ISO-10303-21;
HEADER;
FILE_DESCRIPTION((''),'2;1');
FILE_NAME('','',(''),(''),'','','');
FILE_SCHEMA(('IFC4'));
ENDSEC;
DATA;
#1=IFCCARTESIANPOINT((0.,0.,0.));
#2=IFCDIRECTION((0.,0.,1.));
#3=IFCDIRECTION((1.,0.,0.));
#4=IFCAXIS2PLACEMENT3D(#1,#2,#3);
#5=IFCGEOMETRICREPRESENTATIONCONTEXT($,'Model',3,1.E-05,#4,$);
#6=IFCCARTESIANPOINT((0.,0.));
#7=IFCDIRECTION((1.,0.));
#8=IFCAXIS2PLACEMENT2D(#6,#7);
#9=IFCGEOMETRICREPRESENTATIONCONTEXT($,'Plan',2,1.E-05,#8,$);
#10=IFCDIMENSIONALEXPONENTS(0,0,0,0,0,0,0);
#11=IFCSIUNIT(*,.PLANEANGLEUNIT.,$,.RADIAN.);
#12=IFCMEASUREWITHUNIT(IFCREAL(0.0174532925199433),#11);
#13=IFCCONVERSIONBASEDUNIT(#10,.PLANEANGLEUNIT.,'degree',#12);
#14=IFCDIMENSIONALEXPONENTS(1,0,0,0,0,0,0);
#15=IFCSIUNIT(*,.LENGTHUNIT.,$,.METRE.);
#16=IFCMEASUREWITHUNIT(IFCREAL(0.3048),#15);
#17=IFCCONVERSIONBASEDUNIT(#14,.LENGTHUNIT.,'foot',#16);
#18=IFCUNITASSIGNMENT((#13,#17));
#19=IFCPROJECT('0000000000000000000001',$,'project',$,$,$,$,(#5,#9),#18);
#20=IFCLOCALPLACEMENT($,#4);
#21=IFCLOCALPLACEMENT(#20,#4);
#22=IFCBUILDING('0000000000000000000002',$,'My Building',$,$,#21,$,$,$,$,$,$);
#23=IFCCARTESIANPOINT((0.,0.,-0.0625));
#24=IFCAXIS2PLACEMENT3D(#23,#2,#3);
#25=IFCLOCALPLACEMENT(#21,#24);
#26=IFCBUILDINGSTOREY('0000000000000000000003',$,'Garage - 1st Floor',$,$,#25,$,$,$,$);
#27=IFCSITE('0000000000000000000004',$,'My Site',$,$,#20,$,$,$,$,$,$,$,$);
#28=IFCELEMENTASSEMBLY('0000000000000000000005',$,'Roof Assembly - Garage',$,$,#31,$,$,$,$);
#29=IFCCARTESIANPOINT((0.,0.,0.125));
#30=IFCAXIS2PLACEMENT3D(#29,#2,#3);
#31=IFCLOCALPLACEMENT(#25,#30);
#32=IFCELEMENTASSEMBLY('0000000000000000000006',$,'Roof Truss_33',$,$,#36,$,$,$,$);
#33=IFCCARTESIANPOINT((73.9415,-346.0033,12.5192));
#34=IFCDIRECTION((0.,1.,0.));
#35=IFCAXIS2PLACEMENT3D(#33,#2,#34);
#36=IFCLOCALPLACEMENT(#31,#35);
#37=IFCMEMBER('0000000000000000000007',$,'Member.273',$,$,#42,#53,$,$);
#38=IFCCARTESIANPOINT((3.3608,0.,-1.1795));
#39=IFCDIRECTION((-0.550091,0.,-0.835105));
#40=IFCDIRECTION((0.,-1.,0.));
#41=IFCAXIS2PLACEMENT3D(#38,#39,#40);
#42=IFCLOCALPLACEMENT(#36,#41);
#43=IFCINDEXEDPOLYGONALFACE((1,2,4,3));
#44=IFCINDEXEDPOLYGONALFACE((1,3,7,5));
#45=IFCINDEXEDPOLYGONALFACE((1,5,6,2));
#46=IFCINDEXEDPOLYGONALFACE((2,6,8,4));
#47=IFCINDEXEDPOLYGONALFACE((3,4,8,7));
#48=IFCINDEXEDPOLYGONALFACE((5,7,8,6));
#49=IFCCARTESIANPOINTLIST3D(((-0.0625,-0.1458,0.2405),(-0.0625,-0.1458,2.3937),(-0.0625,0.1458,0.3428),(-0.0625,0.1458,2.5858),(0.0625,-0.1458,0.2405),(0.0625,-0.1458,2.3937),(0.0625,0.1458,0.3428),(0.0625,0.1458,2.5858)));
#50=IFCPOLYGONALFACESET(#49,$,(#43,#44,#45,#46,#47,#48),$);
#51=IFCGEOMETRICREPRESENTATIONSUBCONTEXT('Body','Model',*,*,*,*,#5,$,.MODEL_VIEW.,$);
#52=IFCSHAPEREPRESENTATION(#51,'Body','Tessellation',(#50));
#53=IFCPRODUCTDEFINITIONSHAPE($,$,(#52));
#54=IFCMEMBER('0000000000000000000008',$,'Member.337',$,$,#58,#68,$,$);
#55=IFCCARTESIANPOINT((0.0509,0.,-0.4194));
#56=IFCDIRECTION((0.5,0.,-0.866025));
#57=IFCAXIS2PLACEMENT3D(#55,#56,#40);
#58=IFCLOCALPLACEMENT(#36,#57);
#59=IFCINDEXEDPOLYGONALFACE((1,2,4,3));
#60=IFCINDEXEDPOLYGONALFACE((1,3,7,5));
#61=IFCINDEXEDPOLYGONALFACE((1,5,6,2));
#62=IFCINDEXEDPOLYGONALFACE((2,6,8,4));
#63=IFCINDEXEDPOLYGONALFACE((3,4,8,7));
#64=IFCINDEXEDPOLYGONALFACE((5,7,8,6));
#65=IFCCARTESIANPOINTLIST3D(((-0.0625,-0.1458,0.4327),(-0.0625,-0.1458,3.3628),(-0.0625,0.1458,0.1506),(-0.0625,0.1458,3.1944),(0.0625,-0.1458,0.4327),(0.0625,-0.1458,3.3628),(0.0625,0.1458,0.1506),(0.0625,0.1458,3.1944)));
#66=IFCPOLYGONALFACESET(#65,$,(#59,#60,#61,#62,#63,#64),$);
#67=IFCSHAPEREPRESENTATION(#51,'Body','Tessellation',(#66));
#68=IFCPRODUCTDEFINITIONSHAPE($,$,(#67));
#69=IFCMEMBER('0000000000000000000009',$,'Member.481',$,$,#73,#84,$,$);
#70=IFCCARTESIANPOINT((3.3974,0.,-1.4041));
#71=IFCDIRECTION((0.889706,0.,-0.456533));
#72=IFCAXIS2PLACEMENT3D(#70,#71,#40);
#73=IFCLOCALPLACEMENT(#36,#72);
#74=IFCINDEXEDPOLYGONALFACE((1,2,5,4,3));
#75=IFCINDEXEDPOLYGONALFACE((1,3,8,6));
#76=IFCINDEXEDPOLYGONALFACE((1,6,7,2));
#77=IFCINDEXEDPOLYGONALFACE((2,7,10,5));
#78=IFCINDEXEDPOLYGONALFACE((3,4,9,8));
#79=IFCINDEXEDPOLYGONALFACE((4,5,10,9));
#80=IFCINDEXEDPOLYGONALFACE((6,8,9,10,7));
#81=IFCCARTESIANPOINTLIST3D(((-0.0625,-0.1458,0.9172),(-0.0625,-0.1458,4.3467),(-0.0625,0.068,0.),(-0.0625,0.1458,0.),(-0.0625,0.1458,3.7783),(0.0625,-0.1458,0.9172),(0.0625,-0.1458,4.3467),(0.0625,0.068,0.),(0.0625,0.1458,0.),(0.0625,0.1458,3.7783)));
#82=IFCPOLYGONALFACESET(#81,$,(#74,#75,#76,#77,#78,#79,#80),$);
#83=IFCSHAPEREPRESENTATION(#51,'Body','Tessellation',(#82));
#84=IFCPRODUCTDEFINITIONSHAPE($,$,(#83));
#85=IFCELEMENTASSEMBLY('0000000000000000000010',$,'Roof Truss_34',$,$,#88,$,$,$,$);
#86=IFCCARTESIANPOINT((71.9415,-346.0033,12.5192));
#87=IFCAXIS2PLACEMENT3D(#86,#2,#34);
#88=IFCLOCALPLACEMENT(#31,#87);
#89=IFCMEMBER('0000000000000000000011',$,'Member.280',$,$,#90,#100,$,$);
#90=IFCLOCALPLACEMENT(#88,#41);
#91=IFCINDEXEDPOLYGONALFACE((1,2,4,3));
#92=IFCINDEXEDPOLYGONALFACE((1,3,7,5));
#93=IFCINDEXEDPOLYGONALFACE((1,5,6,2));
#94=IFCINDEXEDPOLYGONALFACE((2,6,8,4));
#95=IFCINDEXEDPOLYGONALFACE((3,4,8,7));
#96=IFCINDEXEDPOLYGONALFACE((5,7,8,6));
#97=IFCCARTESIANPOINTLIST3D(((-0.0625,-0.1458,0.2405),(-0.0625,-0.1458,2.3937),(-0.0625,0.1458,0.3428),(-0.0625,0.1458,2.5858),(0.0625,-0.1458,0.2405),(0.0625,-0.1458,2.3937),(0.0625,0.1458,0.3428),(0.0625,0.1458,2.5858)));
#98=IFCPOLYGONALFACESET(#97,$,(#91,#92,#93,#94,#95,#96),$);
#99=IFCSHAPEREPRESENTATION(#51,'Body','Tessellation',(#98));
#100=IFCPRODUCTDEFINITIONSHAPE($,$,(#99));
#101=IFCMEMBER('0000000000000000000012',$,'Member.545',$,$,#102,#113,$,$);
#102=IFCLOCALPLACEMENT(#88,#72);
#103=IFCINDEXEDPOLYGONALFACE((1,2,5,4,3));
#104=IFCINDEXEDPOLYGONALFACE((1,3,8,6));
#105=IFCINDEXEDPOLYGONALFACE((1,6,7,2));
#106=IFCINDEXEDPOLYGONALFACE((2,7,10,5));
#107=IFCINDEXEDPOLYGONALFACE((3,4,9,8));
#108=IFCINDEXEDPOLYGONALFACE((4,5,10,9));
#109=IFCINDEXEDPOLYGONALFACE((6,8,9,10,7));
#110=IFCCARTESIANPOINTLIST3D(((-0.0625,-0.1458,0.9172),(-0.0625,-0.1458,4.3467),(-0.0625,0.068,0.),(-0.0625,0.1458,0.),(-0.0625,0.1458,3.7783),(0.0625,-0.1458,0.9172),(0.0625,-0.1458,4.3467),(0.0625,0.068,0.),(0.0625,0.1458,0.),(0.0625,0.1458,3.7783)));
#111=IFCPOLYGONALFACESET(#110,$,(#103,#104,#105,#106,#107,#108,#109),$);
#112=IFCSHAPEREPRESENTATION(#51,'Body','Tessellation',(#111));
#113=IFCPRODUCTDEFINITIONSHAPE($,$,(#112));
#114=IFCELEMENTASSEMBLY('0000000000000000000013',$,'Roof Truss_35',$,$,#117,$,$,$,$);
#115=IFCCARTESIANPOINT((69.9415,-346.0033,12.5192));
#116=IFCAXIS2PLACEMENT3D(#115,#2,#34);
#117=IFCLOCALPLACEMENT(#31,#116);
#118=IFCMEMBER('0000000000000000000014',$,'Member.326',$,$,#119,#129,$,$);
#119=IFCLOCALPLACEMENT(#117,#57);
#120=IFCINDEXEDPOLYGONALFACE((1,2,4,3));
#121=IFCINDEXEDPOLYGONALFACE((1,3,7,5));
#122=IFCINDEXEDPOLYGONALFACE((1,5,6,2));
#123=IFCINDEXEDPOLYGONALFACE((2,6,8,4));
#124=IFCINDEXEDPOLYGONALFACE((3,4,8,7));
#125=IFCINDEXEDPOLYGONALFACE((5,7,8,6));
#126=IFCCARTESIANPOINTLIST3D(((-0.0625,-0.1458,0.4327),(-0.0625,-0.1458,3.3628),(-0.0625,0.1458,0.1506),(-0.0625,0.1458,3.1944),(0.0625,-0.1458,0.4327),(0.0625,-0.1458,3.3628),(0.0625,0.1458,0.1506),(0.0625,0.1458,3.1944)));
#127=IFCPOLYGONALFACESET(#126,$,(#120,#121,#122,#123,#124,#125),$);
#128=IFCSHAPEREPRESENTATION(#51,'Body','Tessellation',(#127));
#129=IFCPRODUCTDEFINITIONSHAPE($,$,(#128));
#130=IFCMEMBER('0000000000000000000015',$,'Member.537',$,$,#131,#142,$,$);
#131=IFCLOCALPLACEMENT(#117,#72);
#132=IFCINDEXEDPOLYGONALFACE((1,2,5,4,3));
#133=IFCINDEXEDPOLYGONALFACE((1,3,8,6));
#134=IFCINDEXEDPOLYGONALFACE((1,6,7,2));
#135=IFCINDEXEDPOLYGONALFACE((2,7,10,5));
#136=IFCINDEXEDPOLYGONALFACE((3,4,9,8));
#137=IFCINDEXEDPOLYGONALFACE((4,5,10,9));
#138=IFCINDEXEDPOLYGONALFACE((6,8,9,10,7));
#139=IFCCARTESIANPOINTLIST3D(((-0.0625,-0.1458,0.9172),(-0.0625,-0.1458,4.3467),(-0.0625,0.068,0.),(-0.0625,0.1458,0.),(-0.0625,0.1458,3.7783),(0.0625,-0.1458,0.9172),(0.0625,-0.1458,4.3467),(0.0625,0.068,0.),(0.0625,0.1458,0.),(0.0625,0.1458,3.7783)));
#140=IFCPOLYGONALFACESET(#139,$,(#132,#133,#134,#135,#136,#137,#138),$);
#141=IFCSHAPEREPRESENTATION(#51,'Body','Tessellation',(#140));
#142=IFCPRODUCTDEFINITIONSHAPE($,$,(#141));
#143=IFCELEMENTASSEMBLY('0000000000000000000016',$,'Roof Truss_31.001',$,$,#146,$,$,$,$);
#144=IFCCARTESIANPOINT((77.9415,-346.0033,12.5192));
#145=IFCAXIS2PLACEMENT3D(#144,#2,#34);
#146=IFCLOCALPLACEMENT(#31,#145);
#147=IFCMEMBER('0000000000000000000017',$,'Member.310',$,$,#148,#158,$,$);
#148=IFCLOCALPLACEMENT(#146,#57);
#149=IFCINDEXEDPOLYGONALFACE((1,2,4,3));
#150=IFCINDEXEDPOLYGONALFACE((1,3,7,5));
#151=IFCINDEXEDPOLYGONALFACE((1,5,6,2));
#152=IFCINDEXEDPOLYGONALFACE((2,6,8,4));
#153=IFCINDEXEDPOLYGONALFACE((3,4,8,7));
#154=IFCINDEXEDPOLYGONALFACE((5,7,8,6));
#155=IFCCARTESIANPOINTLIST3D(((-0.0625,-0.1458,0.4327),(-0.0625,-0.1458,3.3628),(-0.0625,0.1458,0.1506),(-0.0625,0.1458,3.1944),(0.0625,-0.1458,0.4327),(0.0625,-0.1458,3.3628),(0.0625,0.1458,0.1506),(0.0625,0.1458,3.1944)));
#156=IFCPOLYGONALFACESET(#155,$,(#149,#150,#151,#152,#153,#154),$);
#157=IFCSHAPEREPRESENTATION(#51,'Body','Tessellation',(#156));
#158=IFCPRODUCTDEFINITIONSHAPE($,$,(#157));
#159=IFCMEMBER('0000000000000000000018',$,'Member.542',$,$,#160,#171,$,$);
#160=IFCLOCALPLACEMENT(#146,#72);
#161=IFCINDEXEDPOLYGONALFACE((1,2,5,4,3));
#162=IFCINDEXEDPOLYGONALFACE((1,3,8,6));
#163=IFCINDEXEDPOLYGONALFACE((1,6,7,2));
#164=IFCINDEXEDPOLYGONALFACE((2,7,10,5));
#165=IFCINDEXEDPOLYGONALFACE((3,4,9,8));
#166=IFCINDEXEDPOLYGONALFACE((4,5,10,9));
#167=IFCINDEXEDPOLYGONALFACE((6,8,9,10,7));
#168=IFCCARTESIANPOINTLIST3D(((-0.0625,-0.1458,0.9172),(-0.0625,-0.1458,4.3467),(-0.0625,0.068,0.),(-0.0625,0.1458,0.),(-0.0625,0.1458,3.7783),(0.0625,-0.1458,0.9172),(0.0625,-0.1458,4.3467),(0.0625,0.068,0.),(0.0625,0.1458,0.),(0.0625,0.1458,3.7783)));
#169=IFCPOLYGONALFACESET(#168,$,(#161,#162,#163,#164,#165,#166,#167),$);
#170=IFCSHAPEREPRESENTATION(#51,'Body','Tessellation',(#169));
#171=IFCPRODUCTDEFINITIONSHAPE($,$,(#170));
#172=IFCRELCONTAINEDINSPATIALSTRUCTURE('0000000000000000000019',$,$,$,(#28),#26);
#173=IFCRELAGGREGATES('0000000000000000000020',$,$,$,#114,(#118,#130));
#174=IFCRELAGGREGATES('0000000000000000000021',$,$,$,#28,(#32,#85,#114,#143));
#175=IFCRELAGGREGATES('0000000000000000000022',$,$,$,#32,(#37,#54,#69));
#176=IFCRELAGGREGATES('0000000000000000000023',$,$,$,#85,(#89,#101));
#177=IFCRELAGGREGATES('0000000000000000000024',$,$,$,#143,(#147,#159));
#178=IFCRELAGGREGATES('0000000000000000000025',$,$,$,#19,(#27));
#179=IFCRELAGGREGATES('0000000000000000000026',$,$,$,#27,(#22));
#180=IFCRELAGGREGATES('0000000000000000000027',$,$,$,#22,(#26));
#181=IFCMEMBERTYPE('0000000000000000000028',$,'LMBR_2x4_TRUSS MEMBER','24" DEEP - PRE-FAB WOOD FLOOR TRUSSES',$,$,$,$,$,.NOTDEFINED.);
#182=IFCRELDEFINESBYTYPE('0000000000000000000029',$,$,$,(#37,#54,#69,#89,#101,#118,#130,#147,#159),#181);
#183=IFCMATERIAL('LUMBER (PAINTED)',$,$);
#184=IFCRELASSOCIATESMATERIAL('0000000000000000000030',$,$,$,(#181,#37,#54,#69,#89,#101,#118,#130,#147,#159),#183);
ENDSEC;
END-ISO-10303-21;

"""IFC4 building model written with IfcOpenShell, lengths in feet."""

from ifc_helpers import new_model, entity, si_unit, converted_unit, frame, origin_with_axes, origin_2d_with_axis, place, context, subcontext, project, spatial, indexed_curve, outline, extrude, clip, halfspace, material, material_profile, profile_set, profile_usage, type_object, element, aggregate, save


model = new_model("IFC4")

# Units and contexts
model_context = context("Model", 3, precision=1e-05, world=origin_with_axes())
plan_context = context("Plan", 2, precision=1e-05, world=origin_2d_with_axis())
body_context = subcontext(model_context, "Body", "Model", "MODEL_VIEW")
ifc_project = project(units=[converted_unit("PLANEANGLEUNIT", "degree", entity("IfcReal", 0.0174532925199433), si_unit("PLANEANGLEUNIT", "RADIAN"), dimensions=[0, 0, 0, 0, 0, 0, 0]), converted_unit("LENGTHUNIT", "foot", entity("IfcReal", 0.3048), si_unit("LENGTHUNIT", "METRE"), dimensions=[1, 0, 0, 0, 0, 0, 0])], contexts=[model_context, plan_context])

# Site, building, storey
site_placement = place(None, origin_with_axes())
site = spatial("IfcSite", under=ifc_project, at=site_placement, Name="My Site")
building_placement = place(site_placement, origin_with_axes())
building = spatial("IfcBuilding", under=site, at=building_placement, Name="My Building")
storey_placement = place(building_placement, frame((0.0, 0.0, -0.0625), z_axis=(0.0, 0.0, 1.0), x_axis=(1.0, 0.0, 0.0)))
storey = spatial("IfcBuildingStorey", under=building, at=storey_placement, Name="Garage - 1st Floor")

# Element assemblies, members
assembly_1_placement = place(storey_placement, frame((0.0, 0.0, 0.125), z_axis=(0.0, 0.0, 1.0), x_axis=(1.0, 0.0, 0.0)))
assembly_1 = element("IfcElementAssembly", 1, at=assembly_1_placement, inside=storey, Name="Roof Assembly - Garage")
assembly_2_placement = place(assembly_1_placement, frame((73.9415, -346.0033, 12.5192), z_axis=(0.0, 0.0, 1.0), x_axis=(0.0, 1.0, 0.0)))
assembly_2 = element("IfcElementAssembly", 2, at=assembly_2_placement, Name="Roof Truss_33")
ifc_material = material(Name="LUMBER (PAINTED)")
ifc_material_profile_1 = material_profile(ifc_material, outline(indexed_curve([(-0.0625, -0.1458), (0.0625, -0.1458), (0.0625, 0.1458), (-0.0625, 0.1458), (-0.0625, -0.1458)])))
ifc_profile_set_1 = profile_set([ifc_material_profile_1])
ifc_profile_usage_1 = profile_usage(ifc_profile_set_1)
member_type_1 = type_object("IfcMemberType", Name="LMBR_2x4_TRUSS MEMBER", Description="24\" DEEP - PRE-FAB WOOD FLOOR TRUSSES", PredefinedType="NOTDEFINED", material=ifc_profile_set_1)
member_1_placement = place(assembly_2_placement, frame((3.3608, 0.0, -1.1795), z_axis=(-0.550091, 0.0, -0.835105), x_axis=(0.0, -1.0, 0.0)))
member_1 = element("IfcMember", 3, at=member_1_placement, type_object=member_type_1, material=ifc_profile_usage_1, Name="Member.273", context=body_context, shape_type="Clipping", body=[
    clip(clip(extrude(outline(indexed_curve([(-0.0625, -0.1458), (0.0625, -0.1458), (0.0625, 0.1458), (-0.0625, 0.1458), (-0.0625, -0.1458)])), origin_with_axes(), (0.0, 0.0, 1.0), 2.7814), halfspace(frame((0.0, 3.2555, 1.4338), z_axis=(0.0, 0.331062, -0.943609), x_axis=(1.0, 0.0, 0.0)), False)), halfspace(frame((0.0, -4.6352, -0.5634), z_axis=(0.0, -0.550091, 0.835105), x_axis=(-1.0, 0.0, 0.0)), False)),
])
ifc_profile_usage_2 = profile_usage(ifc_profile_set_1)
member_2_placement = place(assembly_2_placement, frame((0.0509, 0.0, -0.4194), z_axis=(0.5, 0.0, -0.866025), x_axis=(0.0, -1.0, 0.0)))
member_2 = element("IfcMember", 4, at=member_2_placement, type_object=member_type_1, material=ifc_profile_usage_2, Name="Member.337", context=body_context, shape_type="Clipping", body=[
    clip(clip(extrude(outline(indexed_curve([(-0.0625, -0.1458), (0.0625, -0.1458), (0.0625, 0.1458), (-0.0625, 0.1458), (-0.0625, -0.1458)])), origin_with_axes(), (0.0, 0.0, 1.0), 3.5703), halfspace(frame((0.0, -5.0674, 6.2043), z_axis=(0.0, 0.5, 0.866025), x_axis=(1.0, 0.0, 0.0)), False)), halfspace(frame((0.0, 0.2544, 0.0456), z_axis=(0.0, -0.695161, -0.718855), x_axis=(-1.0, 0.0, 0.0)), False)),
])
ifc_profile_usage_3 = profile_usage(ifc_profile_set_1)
member_3_placement = place(assembly_2_placement, frame((3.3974, 0.0, -1.4041), z_axis=(0.889706, 0.0, -0.456533), x_axis=(0.0, -1.0, 0.0)))
member_3 = element("IfcMember", 5, at=member_3_placement, type_object=member_type_1, material=ifc_profile_usage_3, Name="Member.481", context=body_context, shape_type="Clipping", body=[
    clip(clip(extrude(outline(indexed_curve([(-0.0625, -0.1458), (0.0625, -0.1458), (0.0625, 0.1458), (-0.0625, 0.1458), (-0.0625, -0.1458)])), origin_with_axes(), (0.0, 0.0, 1.0), 4.3542), halfspace(frame((0.0, -0.2419, 4.5339), z_axis=(0.0, 0.889707, 0.456533), x_axis=(1.0, 0.0, 0.0)), False)), halfspace(frame((0.0, 0.8902, -3.5265), z_axis=(0.0, -0.973882, -0.227053), x_axis=(-1.0, 0.0, 0.0)), False)),
])
assembly_3_placement = place(assembly_1_placement, frame((71.9415, -346.0033, 12.5192), z_axis=(0.0, 0.0, 1.0), x_axis=(0.0, 1.0, 0.0)))
assembly_3 = element("IfcElementAssembly", 6, at=assembly_3_placement, Name="Roof Truss_34")
ifc_profile_usage_4 = profile_usage(ifc_profile_set_1)
member_4_placement = place(assembly_3_placement, frame((3.3608, 0.0, -1.1795), z_axis=(-0.550091, 0.0, -0.835105), x_axis=(0.0, -1.0, 0.0)))
member_4 = element("IfcMember", 7, at=member_4_placement, type_object=member_type_1, material=ifc_profile_usage_4, Name="Member.280", context=body_context, shape_type="Clipping", body=[
    clip(clip(extrude(outline(indexed_curve([(-0.0625, -0.1458), (0.0625, -0.1458), (0.0625, 0.1458), (-0.0625, 0.1458), (-0.0625, -0.1458)])), origin_with_axes(), (0.0, 0.0, 1.0), 2.7814), halfspace(frame((0.0, 3.2555, 1.4338), z_axis=(0.0, 0.331062, -0.943609), x_axis=(1.0, 0.0, 0.0)), False)), halfspace(frame((0.0, -4.6352, -0.5634), z_axis=(0.0, -0.550091, 0.835105), x_axis=(-1.0, 0.0, 0.0)), False)),
])
ifc_profile_usage_5 = profile_usage(ifc_profile_set_1)
member_5_placement = place(assembly_3_placement, frame((3.3974, 0.0, -1.4041), z_axis=(0.889706, 0.0, -0.456533), x_axis=(0.0, -1.0, 0.0)))
member_5 = element("IfcMember", 8, at=member_5_placement, type_object=member_type_1, material=ifc_profile_usage_5, Name="Member.545", context=body_context, shape_type="Clipping", body=[
    clip(clip(extrude(outline(indexed_curve([(-0.0625, -0.1458), (0.0625, -0.1458), (0.0625, 0.1458), (-0.0625, 0.1458), (-0.0625, -0.1458)])), origin_with_axes(), (0.0, 0.0, 1.0), 4.3542), halfspace(frame((0.0, -0.2419, 4.5339), z_axis=(0.0, 0.889707, 0.456533), x_axis=(1.0, 0.0, 0.0)), False)), halfspace(frame((0.0, 0.8902, -3.5265), z_axis=(0.0, -0.973882, -0.227053), x_axis=(-1.0, 0.0, 0.0)), False)),
])
assembly_4_placement = place(assembly_1_placement, frame((69.9415, -346.0033, 12.5192), z_axis=(0.0, 0.0, 1.0), x_axis=(0.0, 1.0, 0.0)))
assembly_4 = element("IfcElementAssembly", 9, at=assembly_4_placement, Name="Roof Truss_35")
ifc_profile_usage_6 = profile_usage(ifc_profile_set_1)
member_6_placement = place(assembly_4_placement, frame((0.0509, 0.0, -0.4194), z_axis=(0.5, 0.0, -0.866025), x_axis=(0.0, -1.0, 0.0)))
member_6 = element("IfcMember", 10, at=member_6_placement, type_object=member_type_1, material=ifc_profile_usage_6, Name="Member.326", context=body_context, shape_type="Clipping", body=[
    clip(clip(extrude(outline(indexed_curve([(-0.0625, -0.1458), (0.0625, -0.1458), (0.0625, 0.1458), (-0.0625, 0.1458), (-0.0625, -0.1458)])), origin_with_axes(), (0.0, 0.0, 1.0), 3.5703), halfspace(frame((0.0, -5.0674, 6.2043), z_axis=(0.0, 0.5, 0.866025), x_axis=(1.0, 0.0, 0.0)), False)), halfspace(frame((0.0, 0.2544, 0.0456), z_axis=(0.0, -0.695161, -0.718855), x_axis=(-1.0, 0.0, 0.0)), False)),
])
ifc_profile_usage_7 = profile_usage(ifc_profile_set_1)
member_7_placement = place(assembly_4_placement, frame((3.3974, 0.0, -1.4041), z_axis=(0.889706, 0.0, -0.456533), x_axis=(0.0, -1.0, 0.0)))
member_7 = element("IfcMember", 11, at=member_7_placement, type_object=member_type_1, material=ifc_profile_usage_7, Name="Member.537", context=body_context, shape_type="Clipping", body=[
    clip(clip(extrude(outline(indexed_curve([(-0.0625, -0.1458), (0.0625, -0.1458), (0.0625, 0.1458), (-0.0625, 0.1458), (-0.0625, -0.1458)])), origin_with_axes(), (0.0, 0.0, 1.0), 4.3542), halfspace(frame((0.0, -0.2419, 4.5339), z_axis=(0.0, 0.889707, 0.456533), x_axis=(1.0, 0.0, 0.0)), False)), halfspace(frame((0.0, 0.8902, -3.5265), z_axis=(0.0, -0.973882, -0.227053), x_axis=(-1.0, 0.0, 0.0)), False)),
])
aggregate(assembly_4, [member_6, member_7])
assembly_5_placement = place(assembly_1_placement, frame((77.9415, -346.0033, 12.5192), z_axis=(0.0, 0.0, 1.0), x_axis=(0.0, 1.0, 0.0)))
assembly_5 = element("IfcElementAssembly", 12, at=assembly_5_placement, Name="Roof Truss_31.001")
ifc_profile_usage_8 = profile_usage(ifc_profile_set_1)
member_8_placement = place(assembly_5_placement, frame((0.0509, 0.0, -0.4194), z_axis=(0.5, 0.0, -0.866025), x_axis=(0.0, -1.0, 0.0)))
member_8 = element("IfcMember", 13, at=member_8_placement, type_object=member_type_1, material=ifc_profile_usage_8, Name="Member.310", context=body_context, shape_type="Clipping", body=[
    clip(clip(extrude(outline(indexed_curve([(-0.0625, -0.1458), (0.0625, -0.1458), (0.0625, 0.1458), (-0.0625, 0.1458), (-0.0625, -0.1458)])), origin_with_axes(), (0.0, 0.0, 1.0), 3.5703), halfspace(frame((0.0, -5.0674, 6.2043), z_axis=(0.0, 0.5, 0.866025), x_axis=(1.0, 0.0, 0.0)), False)), halfspace(frame((0.0, 0.2544, 0.0456), z_axis=(0.0, -0.695161, -0.718855), x_axis=(-1.0, 0.0, 0.0)), False)),
])
ifc_profile_usage_9 = profile_usage(ifc_profile_set_1)
member_9_placement = place(assembly_5_placement, frame((3.3974, 0.0, -1.4041), z_axis=(0.889706, 0.0, -0.456533), x_axis=(0.0, -1.0, 0.0)))
member_9 = element("IfcMember", 14, at=member_9_placement, type_object=member_type_1, material=ifc_profile_usage_9, Name="Member.542", context=body_context, shape_type="Clipping", body=[
    clip(clip(extrude(outline(indexed_curve([(-0.0625, -0.1458), (0.0625, -0.1458), (0.0625, 0.1458), (-0.0625, 0.1458), (-0.0625, -0.1458)])), origin_with_axes(), (0.0, 0.0, 1.0), 4.3542), halfspace(frame((0.0, -0.2419, 4.5339), z_axis=(0.0, 0.889707, 0.456533), x_axis=(1.0, 0.0, 0.0)), False)), halfspace(frame((0.0, 0.8902, -3.5265), z_axis=(0.0, -0.973882, -0.227053), x_axis=(-1.0, 0.0, 0.0)), False)),
])
aggregate(assembly_1, [assembly_2, assembly_3, assembly_4, assembly_5])
aggregate(assembly_2, [member_1, member_2, member_3])
aggregate(assembly_3, [member_4, member_5])
aggregate(assembly_5, [member_8, member_9])

save(model, "model.ifc")
